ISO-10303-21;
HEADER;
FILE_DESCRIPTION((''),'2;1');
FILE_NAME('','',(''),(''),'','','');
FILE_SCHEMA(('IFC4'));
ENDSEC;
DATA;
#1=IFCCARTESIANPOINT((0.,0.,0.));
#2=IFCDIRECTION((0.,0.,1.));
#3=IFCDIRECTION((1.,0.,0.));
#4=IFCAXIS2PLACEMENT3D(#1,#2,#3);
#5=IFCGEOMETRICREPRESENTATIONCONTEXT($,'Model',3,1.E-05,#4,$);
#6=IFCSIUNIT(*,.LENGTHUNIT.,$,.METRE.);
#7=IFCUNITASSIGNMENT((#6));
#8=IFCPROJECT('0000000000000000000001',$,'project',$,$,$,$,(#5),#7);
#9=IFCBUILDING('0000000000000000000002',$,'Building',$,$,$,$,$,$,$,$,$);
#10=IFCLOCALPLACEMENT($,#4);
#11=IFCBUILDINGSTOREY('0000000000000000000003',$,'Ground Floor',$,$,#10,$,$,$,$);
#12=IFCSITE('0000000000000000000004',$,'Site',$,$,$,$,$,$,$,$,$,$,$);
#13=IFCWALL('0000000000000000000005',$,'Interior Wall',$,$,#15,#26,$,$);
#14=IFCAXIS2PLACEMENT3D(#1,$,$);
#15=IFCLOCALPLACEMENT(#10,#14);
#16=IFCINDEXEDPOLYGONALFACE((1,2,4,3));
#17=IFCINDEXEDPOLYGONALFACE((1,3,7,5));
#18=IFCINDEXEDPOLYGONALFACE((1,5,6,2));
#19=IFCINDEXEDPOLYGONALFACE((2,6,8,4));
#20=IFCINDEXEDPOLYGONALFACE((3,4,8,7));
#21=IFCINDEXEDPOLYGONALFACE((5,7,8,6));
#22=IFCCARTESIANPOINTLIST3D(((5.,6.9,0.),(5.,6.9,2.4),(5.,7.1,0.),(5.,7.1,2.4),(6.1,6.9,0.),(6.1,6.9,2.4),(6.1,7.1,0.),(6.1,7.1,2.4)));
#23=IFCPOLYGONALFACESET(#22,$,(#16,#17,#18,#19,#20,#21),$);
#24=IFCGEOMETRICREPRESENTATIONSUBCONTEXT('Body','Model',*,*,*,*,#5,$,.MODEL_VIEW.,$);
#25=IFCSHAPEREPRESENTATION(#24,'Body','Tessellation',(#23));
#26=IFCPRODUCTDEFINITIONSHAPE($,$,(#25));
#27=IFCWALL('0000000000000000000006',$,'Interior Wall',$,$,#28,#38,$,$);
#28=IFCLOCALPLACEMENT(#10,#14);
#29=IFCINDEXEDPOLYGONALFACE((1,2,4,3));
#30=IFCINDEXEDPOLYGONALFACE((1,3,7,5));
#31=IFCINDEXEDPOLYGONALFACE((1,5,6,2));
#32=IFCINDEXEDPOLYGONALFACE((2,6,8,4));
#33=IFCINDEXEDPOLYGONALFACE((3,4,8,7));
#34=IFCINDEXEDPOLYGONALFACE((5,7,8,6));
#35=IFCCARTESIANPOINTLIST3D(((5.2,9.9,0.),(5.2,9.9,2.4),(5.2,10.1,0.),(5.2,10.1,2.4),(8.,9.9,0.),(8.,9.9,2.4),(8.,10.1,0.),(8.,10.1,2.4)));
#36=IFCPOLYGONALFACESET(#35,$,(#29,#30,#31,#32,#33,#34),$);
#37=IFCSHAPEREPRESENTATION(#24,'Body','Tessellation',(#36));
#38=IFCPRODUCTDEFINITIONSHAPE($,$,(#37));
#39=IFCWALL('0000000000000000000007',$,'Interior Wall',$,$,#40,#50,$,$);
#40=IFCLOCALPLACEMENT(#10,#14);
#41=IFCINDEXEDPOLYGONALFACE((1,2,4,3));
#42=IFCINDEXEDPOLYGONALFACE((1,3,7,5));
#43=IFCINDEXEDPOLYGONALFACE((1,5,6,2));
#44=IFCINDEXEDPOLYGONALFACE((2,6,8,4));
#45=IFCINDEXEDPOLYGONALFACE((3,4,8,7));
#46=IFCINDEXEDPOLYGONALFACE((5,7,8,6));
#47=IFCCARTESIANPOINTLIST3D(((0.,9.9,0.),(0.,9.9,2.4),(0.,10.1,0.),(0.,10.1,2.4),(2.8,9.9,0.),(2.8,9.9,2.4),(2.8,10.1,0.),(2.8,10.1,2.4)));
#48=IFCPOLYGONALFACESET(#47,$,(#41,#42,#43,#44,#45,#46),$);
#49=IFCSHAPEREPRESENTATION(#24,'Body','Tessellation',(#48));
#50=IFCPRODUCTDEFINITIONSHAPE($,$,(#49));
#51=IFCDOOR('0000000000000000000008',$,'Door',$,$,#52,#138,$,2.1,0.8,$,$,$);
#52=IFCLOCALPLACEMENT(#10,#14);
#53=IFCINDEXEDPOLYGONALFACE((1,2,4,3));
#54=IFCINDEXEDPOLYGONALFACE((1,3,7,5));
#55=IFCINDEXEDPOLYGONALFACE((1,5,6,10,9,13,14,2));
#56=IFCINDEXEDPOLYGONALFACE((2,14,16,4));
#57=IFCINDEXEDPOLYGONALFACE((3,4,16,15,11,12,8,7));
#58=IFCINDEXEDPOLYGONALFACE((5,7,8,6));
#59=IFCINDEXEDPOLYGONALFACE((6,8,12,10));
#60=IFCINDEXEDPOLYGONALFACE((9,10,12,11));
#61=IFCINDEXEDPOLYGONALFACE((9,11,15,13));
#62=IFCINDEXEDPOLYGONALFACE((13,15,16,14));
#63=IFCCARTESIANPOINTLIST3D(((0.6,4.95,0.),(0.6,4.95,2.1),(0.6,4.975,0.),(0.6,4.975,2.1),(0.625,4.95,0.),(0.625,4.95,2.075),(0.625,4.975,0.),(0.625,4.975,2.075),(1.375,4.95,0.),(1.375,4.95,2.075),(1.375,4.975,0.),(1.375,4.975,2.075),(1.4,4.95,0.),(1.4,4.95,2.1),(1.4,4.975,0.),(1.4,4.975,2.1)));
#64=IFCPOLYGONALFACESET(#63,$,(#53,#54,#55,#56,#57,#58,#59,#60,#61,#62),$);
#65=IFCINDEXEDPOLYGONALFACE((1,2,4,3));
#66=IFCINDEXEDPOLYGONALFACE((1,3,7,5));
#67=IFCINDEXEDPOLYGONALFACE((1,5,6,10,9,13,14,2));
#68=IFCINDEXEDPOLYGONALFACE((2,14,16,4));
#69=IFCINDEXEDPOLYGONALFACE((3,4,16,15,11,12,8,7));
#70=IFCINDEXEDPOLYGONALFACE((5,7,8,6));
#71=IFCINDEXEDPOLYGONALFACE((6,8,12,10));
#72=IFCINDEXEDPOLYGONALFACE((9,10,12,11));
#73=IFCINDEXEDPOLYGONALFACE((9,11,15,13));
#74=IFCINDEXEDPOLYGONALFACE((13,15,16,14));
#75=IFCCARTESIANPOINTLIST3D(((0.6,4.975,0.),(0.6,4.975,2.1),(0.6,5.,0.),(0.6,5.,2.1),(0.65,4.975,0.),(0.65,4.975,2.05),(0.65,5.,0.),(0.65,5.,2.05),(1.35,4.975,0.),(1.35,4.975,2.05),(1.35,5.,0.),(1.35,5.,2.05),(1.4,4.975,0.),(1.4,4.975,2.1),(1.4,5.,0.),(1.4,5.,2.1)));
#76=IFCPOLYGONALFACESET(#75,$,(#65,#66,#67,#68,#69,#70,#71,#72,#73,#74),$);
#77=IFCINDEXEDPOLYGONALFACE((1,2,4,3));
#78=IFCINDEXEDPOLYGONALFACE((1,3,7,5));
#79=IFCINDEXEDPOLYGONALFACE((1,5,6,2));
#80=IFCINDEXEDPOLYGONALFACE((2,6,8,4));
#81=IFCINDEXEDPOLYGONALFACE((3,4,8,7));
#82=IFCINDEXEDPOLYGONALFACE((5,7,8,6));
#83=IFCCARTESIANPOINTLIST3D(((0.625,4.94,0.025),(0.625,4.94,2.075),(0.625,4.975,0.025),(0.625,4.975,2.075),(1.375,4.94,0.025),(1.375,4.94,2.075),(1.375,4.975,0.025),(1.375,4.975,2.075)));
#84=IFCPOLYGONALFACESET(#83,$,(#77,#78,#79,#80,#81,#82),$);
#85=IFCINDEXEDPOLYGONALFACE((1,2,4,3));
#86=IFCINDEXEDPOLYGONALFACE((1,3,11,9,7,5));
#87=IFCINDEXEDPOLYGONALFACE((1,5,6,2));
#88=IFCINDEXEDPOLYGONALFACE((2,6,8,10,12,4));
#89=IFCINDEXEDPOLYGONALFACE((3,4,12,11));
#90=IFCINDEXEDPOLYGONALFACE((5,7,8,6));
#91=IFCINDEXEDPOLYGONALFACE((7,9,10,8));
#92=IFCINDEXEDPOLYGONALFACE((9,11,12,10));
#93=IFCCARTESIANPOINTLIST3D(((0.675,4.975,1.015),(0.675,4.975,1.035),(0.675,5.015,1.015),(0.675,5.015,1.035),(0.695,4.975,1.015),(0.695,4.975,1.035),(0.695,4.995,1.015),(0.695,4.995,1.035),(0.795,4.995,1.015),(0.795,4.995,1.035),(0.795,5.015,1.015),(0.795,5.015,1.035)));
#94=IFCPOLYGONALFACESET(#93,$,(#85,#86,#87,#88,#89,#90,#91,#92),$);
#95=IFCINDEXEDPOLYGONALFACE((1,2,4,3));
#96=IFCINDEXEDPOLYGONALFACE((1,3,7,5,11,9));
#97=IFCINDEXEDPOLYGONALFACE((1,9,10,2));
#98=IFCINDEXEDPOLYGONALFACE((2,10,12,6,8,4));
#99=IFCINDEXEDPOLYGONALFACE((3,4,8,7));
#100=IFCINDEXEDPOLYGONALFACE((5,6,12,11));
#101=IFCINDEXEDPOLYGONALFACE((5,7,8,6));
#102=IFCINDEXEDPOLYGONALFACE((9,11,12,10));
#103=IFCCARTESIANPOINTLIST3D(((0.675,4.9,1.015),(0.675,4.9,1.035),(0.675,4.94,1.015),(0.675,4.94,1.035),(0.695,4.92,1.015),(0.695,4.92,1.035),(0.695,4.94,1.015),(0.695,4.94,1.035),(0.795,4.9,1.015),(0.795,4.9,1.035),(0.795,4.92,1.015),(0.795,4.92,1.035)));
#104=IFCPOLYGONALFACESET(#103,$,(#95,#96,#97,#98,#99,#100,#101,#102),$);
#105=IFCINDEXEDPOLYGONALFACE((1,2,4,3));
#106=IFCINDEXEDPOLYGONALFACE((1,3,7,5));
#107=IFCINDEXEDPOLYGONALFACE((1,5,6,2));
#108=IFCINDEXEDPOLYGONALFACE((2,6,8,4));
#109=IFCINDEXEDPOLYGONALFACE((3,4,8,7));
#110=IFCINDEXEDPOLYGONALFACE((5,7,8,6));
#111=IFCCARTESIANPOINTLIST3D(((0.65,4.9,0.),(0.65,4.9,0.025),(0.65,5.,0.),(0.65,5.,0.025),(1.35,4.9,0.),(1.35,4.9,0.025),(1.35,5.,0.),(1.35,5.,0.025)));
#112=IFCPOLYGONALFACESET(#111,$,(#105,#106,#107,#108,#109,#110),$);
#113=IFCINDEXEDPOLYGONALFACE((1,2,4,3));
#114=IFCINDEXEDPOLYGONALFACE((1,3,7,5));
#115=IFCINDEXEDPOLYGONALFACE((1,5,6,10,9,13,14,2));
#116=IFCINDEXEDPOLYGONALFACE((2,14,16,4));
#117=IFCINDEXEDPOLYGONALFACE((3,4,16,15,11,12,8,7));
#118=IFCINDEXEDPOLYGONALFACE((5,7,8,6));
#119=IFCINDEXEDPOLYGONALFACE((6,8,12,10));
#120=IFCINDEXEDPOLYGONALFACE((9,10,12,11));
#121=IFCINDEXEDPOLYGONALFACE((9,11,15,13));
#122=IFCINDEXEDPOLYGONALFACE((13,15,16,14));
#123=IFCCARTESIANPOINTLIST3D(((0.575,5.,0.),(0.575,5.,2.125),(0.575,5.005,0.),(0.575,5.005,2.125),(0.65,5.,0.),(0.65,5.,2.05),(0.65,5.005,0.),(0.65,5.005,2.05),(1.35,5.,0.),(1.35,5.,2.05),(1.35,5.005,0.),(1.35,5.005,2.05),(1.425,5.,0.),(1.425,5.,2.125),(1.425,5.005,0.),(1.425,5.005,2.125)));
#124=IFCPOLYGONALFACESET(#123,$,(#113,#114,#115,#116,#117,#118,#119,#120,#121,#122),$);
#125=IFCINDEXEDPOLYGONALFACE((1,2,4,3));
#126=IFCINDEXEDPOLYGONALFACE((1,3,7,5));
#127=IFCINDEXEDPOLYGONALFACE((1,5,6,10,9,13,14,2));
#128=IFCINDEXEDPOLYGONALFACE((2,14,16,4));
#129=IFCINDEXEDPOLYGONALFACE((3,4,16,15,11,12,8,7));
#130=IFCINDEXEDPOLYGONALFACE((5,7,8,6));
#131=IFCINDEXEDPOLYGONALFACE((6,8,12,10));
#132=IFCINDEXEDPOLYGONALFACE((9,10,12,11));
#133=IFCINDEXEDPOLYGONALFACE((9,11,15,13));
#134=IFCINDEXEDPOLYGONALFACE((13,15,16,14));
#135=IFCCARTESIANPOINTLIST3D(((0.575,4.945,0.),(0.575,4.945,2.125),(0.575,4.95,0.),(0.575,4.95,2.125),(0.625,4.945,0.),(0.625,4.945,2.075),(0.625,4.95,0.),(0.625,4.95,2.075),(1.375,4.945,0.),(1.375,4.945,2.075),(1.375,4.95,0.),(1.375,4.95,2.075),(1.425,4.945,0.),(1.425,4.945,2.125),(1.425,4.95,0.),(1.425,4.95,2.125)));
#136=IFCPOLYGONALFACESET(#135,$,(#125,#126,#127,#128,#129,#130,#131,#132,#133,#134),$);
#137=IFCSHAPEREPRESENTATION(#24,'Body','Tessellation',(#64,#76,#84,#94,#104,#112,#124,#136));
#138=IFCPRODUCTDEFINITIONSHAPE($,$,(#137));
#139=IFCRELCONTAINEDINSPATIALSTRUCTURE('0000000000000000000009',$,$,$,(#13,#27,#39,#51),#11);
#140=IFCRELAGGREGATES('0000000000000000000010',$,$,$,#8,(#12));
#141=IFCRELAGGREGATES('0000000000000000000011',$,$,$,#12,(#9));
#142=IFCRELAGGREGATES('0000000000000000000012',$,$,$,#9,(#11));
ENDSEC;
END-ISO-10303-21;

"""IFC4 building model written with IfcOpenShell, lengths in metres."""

from ifc_helpers import new_model, si_unit, frame, origin_with_axes, place, context, subcontext, project, spatial, line, indexed_curve, outline, extrude, element, save


model = new_model("IFC4")

# Units and contexts
model_context = context("Model", 3, precision=1e-05, world=origin_with_axes())
body_context = subcontext(model_context, "Body", "Model", "MODEL_VIEW")
ifc_project = project(units=[si_unit("LENGTHUNIT", "METRE")], contexts=[model_context])

# Site, building, storey
site = spatial("IfcSite", under=ifc_project, Name="Site")
building = spatial("IfcBuilding", under=site, Name="Building")
storey_placement = place(None, origin_with_axes())
storey = spatial("IfcBuildingStorey", under=building, at=storey_placement, Name="Ground Floor")

# Walls
for number, where, z_axis, x_axis, name in (
    (1, (6.1, 7.0, 0.0), (0.0, 0.0, 1.0), (-1.0, 0.0, 0.0), "Interior Wall"),
):
    element("IfcWall", number, at=place(storey_placement, frame(where, z_axis=z_axis, x_axis=x_axis)), inside=storey, Name=name, context=body_context, shape_type="SweptSolid", body=[
        extrude(outline(indexed_curve([(0.0, 0.0), (0.0, 0.2), (1.1, 0.2), (1.1, 0.0), (0.0, 0.0)], self_intersect=False)), frame((0.0, -0.1, 0.0), z_axis=(0.0, 0.0, 1.0), x_axis=(1.0, 0.0, 0.0)), (0.0, 0.0, 1.0), 2.4),
    ])
for number, where, z_axis, x_axis, name in (
    (2, (8.0, 10.0, 0.0), (0.0, 0.0, 1.0), (-1.0, 0.0, 0.0), "Interior Wall"),
    (3, (2.8, 10.0, 0.0), (0.0, 0.0, 1.0), (-1.0, 0.0, 0.0), "Interior Wall"),
):
    element("IfcWall", number, at=place(storey_placement, frame(where, z_axis=z_axis, x_axis=x_axis)), inside=storey, Name=name, context=body_context, shape_type="SweptSolid", body=[
        extrude(outline(indexed_curve([(0.0, 0.0), (0.0, 0.2), (2.8, 0.2), (2.8, 0.0), (0.0, 0.0)], self_intersect=False)), frame((0.0, -0.1, 0.0), z_axis=(0.0, 0.0, 1.0), x_axis=(1.0, 0.0, 0.0)), (0.0, 0.0, 1.0), 2.4),
    ])

# Door
door_1_placement = place(storey_placement, frame((1.4, 5.0, 0.0), z_axis=(0.0, 0.0, 1.0), x_axis=(-1.0, 0.0, 0.0)))
element("IfcDoor", 4, at=door_1_placement, inside=storey, Name="Door", OverallHeight=2.1, OverallWidth=0.8, context=body_context, shape_type="SweptSolid", body=[
    extrude(outline(indexed_curve([(0.0, 0.0), (0.0, 2.1), (0.8, 2.1), (0.8, 0.0), (0.775, 0.0), (0.775, 2.075), (0.025, 2.075), (0.025, 0.0)], segments=[line(1, 2, 3, 4, 5, 6, 7, 8, 1)])), frame((0.0, 0.025, 0.0), z_axis=(0.0, -1.0, 0.0), x_axis=(1.0, 0.0, 0.0)), (0.0, 0.0, -1.0), 0.025),
    extrude(outline(indexed_curve([(0.0, 0.0), (0.0, 2.1), (0.8, 2.1), (0.8, 0.0), (0.75, 0.0), (0.75, 2.05), (0.05, 2.05), (0.05, 0.0)], segments=[line(1, 2, 3, 4, 5, 6, 7, 8, 1)])), frame((0.0, 0.0, 0.0), z_axis=(0.0, -1.0, 0.0), x_axis=(1.0, 0.0, 0.0)), (0.0, 0.0, -1.0), 0.025),
    extrude(outline(indexed_curve([(0.0, 0.0), (0.75, 0.0), (0.75, 0.035), (0.0, 0.035)], segments=[line(1, 2, 3, 4, 1)])), frame((0.025, 0.025, 0.025), z_axis=(0.0, 0.0, 1.0), x_axis=(1.0, 0.0, 0.0)), (0.0, 0.0, 1.0), 2.05),
    extrude(outline(indexed_curve([(0.0, 0.0), (0.0, -0.04), (-0.12, -0.04), (-0.12, -0.02), (-0.02, -0.02), (-0.02, 0.0)], segments=[line(1, 2, 3, 4, 5, 6, 1)])), frame((0.725, 0.025, 1.015), z_axis=(0.0, 0.0, 1.0), x_axis=(1.0, 0.0, 0.0)), (0.0, 0.0, 1.0), 0.02),
    extrude(outline(indexed_curve([(0.0, 0.0), (0.0, 0.04), (-0.12, 0.04), (-0.12, 0.02), (-0.02, 0.02), (-0.02, 0.0)], segments=[line(1, 2, 3, 4, 5, 6, 1)])), frame((0.725, 0.06, 1.015), z_axis=(0.0, 0.0, 1.0), x_axis=(1.0, 0.0, 0.0)), (0.0, 0.0, 1.0), 0.02),
    extrude(outline(indexed_curve([(0.0, 0.0), (0.7, 0.0), (0.7, 0.1), (0.0, 0.1)], segments=[line(1, 2, 3, 4, 1)])), frame((0.05, 0.0, 0.0), z_axis=(0.0, 0.0, 1.0), x_axis=(1.0, 0.0, 0.0)), (0.0, 0.0, 1.0), 0.025),
    extrude(outline(indexed_curve([(0.0, 0.0), (0.0, 2.125), (0.85, 2.125), (0.85, 0.0), (0.775, 0.0), (0.775, 2.05), (0.075, 2.05), (0.075, 0.0)], segments=[line(1, 2, 3, 4, 5, 6, 7, 8, 1)])), frame((-0.025, -0.005, 0.0), z_axis=(0.0, -1.0, 0.0), x_axis=(1.0, 0.0, 0.0)), (0.0, 0.0, -1.0), 0.005),
    extrude(outline(indexed_curve([(0.0, 0.0), (0.0, 2.125), (0.85, 2.125), (0.85, 0.0), (0.8, 0.0), (0.8, 2.075), (0.05, 2.075), (0.05, 0.0)], segments=[line(1, 2, 3, 4, 5, 6, 7, 8, 1)])), frame((-0.025, 0.05, 0.0), z_axis=(0.0, -1.0, 0.0), x_axis=(1.0, 0.0, 0.0)), (0.0, 0.0, -1.0), 0.005),
])

save(model, "model.ifc")
